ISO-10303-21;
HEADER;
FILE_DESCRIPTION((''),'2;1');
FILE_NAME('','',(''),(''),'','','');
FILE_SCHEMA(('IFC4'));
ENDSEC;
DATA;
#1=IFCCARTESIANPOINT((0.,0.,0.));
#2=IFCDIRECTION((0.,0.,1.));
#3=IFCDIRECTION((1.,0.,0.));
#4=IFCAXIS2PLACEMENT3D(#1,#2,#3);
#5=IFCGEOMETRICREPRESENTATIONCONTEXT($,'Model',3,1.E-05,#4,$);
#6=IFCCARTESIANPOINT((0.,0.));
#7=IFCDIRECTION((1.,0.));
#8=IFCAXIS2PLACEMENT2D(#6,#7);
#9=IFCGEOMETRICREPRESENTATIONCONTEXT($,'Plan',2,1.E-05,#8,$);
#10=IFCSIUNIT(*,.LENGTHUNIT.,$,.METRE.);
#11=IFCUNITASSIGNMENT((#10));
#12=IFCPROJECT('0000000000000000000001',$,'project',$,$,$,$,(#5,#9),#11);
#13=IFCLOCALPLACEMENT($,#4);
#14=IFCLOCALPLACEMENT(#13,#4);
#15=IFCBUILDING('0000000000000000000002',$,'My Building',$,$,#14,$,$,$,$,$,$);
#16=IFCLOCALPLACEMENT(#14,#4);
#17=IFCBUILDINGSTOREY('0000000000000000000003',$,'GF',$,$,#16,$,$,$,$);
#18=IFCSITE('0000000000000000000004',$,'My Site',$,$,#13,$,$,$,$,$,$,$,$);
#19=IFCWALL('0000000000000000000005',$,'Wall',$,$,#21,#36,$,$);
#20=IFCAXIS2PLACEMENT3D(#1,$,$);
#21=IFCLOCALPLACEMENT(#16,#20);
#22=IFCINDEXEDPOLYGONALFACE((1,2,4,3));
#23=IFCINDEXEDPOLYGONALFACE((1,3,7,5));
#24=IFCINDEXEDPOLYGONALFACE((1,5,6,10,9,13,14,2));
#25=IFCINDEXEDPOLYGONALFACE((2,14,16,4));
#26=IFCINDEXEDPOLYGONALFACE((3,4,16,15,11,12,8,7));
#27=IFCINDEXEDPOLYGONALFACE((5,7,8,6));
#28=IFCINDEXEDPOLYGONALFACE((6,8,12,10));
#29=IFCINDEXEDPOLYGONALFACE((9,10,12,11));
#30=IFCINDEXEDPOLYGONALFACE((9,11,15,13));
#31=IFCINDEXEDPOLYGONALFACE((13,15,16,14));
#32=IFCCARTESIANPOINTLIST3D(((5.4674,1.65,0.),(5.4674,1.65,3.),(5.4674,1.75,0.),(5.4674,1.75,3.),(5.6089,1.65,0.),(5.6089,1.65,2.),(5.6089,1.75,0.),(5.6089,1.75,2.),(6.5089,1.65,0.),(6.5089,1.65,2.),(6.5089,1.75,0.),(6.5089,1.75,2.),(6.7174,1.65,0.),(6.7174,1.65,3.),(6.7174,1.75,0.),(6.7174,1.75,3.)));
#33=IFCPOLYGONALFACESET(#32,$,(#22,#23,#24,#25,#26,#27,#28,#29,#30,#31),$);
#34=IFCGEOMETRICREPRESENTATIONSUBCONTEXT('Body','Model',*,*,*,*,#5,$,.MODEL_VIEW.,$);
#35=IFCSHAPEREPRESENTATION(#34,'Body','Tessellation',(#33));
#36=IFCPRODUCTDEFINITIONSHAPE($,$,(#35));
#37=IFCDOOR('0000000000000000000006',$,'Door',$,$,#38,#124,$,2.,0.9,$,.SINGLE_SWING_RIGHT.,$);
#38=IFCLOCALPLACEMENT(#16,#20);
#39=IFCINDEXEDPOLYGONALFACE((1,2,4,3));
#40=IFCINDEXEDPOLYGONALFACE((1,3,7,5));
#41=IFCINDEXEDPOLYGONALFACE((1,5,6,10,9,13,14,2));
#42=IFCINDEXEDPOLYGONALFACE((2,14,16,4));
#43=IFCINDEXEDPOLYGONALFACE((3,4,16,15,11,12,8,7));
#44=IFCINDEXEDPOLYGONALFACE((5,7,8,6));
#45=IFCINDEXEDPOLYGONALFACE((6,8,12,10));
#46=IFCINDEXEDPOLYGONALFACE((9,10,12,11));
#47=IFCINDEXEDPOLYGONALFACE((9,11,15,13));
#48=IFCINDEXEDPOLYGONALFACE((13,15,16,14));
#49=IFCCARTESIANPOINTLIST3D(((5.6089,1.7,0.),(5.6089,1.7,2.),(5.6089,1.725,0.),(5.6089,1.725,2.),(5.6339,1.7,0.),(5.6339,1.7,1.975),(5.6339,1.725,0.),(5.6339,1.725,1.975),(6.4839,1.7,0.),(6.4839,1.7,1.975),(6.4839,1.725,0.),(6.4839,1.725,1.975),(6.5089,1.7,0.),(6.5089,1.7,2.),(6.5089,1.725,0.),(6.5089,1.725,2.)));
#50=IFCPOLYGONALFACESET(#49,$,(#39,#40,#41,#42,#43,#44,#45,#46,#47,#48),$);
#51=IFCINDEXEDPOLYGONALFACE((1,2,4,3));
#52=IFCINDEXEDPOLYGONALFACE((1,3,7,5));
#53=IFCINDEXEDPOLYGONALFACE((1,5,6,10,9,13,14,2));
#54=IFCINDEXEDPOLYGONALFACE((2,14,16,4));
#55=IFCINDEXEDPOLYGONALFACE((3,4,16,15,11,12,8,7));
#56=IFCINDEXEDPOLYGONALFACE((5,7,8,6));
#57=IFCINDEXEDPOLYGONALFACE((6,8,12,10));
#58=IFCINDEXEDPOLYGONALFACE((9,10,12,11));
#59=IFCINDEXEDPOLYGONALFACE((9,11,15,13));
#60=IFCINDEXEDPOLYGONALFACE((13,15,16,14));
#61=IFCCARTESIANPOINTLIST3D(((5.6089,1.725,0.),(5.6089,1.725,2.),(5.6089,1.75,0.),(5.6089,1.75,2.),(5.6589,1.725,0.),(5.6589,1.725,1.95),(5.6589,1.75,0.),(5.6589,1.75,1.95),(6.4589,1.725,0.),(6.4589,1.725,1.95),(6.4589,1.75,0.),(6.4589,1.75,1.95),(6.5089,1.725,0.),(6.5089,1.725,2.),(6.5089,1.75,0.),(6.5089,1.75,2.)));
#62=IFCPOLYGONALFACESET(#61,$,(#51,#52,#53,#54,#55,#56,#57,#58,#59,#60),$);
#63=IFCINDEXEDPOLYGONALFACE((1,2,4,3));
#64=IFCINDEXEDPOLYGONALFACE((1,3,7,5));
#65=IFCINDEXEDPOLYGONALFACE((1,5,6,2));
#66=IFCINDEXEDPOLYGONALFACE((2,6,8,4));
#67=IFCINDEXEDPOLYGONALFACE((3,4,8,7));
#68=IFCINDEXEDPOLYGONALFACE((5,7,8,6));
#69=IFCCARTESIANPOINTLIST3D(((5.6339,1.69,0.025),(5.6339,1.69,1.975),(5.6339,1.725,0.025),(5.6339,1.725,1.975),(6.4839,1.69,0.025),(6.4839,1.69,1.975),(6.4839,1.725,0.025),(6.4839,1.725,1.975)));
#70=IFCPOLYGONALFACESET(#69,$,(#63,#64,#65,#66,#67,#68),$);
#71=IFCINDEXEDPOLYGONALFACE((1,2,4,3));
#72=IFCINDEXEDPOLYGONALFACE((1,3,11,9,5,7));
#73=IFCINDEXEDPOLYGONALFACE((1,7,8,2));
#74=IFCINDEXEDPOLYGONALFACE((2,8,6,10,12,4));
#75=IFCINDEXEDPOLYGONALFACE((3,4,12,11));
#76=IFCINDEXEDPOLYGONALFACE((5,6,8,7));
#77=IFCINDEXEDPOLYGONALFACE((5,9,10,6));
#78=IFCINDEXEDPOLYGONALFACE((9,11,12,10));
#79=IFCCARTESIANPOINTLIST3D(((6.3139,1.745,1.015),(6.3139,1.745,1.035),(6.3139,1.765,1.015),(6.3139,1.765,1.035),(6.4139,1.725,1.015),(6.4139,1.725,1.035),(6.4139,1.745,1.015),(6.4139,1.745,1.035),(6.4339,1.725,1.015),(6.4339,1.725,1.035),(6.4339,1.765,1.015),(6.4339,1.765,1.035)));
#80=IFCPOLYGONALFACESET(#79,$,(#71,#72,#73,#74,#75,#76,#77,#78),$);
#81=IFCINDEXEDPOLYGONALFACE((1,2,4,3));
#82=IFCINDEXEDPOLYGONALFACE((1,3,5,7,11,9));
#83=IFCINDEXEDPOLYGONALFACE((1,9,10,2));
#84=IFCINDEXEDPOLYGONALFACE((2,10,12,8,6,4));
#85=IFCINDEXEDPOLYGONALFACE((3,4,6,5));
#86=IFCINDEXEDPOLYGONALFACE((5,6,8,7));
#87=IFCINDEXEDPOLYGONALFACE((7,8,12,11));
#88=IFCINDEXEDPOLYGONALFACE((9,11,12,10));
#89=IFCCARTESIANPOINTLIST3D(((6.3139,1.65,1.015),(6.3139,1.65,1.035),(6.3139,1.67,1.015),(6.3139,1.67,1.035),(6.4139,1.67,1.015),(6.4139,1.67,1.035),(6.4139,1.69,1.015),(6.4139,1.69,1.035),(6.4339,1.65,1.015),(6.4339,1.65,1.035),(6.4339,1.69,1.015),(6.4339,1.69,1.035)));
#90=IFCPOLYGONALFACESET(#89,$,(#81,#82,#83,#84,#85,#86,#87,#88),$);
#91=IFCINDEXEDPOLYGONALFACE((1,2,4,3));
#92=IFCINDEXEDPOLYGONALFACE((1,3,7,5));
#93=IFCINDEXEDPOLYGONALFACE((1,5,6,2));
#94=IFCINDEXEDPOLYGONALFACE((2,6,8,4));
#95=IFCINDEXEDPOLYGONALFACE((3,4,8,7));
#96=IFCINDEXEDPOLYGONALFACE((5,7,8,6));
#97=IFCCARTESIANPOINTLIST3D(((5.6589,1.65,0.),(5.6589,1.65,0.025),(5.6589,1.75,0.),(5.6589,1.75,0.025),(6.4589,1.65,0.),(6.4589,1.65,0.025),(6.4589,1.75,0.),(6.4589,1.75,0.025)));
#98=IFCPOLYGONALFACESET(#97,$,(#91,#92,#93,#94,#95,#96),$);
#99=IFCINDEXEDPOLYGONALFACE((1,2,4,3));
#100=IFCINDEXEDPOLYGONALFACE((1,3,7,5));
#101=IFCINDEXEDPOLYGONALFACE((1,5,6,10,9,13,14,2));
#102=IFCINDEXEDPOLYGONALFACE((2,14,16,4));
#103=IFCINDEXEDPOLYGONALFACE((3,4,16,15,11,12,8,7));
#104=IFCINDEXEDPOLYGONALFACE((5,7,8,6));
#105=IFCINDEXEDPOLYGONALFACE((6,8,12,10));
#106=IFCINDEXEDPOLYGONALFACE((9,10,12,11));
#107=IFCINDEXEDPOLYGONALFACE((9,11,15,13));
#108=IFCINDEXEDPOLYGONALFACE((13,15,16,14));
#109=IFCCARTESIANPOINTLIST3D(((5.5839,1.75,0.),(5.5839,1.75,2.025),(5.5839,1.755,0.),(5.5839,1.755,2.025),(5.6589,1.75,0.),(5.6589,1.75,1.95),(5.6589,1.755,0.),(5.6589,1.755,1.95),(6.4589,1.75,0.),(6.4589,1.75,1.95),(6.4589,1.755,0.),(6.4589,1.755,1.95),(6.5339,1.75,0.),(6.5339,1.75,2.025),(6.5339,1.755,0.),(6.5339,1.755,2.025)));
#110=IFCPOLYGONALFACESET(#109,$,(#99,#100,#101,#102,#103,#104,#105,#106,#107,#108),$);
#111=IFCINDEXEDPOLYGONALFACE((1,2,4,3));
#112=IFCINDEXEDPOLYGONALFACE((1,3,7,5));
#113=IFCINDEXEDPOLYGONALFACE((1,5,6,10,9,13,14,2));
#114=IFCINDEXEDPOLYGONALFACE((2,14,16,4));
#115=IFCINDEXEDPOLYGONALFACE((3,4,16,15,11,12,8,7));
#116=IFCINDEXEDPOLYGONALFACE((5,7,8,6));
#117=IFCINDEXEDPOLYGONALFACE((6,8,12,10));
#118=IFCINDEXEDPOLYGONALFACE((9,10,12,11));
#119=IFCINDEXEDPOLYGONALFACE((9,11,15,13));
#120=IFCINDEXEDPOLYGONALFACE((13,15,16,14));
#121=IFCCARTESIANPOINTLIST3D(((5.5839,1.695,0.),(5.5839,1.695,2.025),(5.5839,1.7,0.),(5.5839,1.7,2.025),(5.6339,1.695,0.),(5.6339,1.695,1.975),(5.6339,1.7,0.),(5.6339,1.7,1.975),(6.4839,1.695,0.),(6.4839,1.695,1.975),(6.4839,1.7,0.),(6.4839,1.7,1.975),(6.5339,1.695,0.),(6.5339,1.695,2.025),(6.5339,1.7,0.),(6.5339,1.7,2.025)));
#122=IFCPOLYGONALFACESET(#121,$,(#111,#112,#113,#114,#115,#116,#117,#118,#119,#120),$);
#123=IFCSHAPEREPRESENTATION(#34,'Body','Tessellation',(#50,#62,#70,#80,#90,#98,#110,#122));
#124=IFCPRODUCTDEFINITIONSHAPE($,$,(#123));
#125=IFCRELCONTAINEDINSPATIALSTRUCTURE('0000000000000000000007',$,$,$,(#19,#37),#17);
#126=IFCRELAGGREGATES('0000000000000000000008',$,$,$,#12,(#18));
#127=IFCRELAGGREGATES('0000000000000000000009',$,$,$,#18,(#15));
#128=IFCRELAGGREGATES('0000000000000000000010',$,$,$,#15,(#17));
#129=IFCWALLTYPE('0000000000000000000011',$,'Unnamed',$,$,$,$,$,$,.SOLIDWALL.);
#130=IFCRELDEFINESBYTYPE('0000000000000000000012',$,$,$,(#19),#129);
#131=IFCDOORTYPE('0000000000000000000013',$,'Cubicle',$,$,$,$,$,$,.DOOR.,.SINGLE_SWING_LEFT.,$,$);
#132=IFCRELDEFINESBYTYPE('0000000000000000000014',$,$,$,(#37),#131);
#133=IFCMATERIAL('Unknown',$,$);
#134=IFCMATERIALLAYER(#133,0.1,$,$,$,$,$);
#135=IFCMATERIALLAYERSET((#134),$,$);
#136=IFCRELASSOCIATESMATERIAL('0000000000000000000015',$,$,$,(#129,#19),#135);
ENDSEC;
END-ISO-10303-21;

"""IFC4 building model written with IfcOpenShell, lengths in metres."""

from ifc_helpers import new_model, entity, si_unit, frame, origin_with_axes, origin_2d_with_axis, place, context, subcontext, project, spatial, line, indexed_curve, outline, extrude, shape, source, transform, mapped, material, layer, layer_set, layer_usage, type_object, type_shapes, element, fill, save


model = new_model("IFC4")

# Units and contexts
model_context = context("Model", 3, precision=1e-05, world=origin_with_axes())
plan_context = context("Plan", 2, precision=1e-05, world=origin_2d_with_axis())
body_context_1 = subcontext(model_context, "Body", "Model", "MODEL_VIEW")
body_context_2 = subcontext(plan_context, "Body", "Plan", "PLAN_VIEW")
ifc_project = project(units=[si_unit("LENGTHUNIT", "METRE")], contexts=[model_context, plan_context])

# Site, building, storey
site_placement = place(None, origin_with_axes())
site = spatial("IfcSite", under=ifc_project, at=site_placement, Name="My Site")
building_placement = place(site_placement, origin_with_axes())
building = spatial("IfcBuilding", under=site, at=building_placement, Name="My Building")
storey_placement = place(building_placement, origin_with_axes())
storey = spatial("IfcBuildingStorey", under=building, at=storey_placement, Name="GF")

# Shared definitions
ifc_material = material(Name="Unknown")

# Shared definitions
ifc_layer_1 = layer(ifc_material, 0.1)
ifc_layer_set_1 = layer_set([ifc_layer_1])
wall_type = type_object("IfcWallType", Name="Unnamed", PredefinedType="SOLIDWALL", material=ifc_layer_set_1)

# Wall, opening, door
shared_shape_1 = source(origin_with_axes(), body_context_1, "Body", "SweptSolid", [
    extrude(outline(indexed_curve([(0.0, 0.0), (0.9, 0.0), (0.9, 2.0), (0.0, 2.0)], segments=[line(1, 2, 3, 4, 1)])), frame((0.0, -0.6, 0.0), z_axis=(0.0, -1.0, 0.0), x_axis=(1.0, 0.0, 0.0)), (0.0, 0.0, -1.0), 1.2),
])
door_type = type_object("IfcDoorType", Name="Cubicle", OperationType="SINGLE_SWING_LEFT", PredefinedType="DOOR")
shared_shape_2 = source(origin_with_axes(), body_context_1, "Body", "SweptSolid", [
    extrude(outline(indexed_curve([(0.0, 0.0), (0.0, 2.0), (0.9, 2.0), (0.9, 0.0), (0.875, 0.0), (0.875, 1.975), (0.025, 1.975), (0.025, 0.0)], segments=[line(1, 2, 3, 4, 5, 6, 7, 8, 1)])), frame((0.0, 0.025, 0.0), z_axis=(0.0, -1.0, 0.0), x_axis=(1.0, 0.0, 0.0)), (0.0, 0.0, -1.0), 0.025),
    extrude(outline(indexed_curve([(0.0, 0.0), (0.0, 2.0), (0.9, 2.0), (0.9, 0.0), (0.85, 0.0), (0.85, 1.95), (0.05, 1.95), (0.05, 0.0)], segments=[line(1, 2, 3, 4, 5, 6, 7, 8, 1)])), frame((0.0, 0.0, 0.0), z_axis=(0.0, -1.0, 0.0), x_axis=(1.0, 0.0, 0.0)), (0.0, 0.0, -1.0), 0.025),
    extrude(outline(indexed_curve([(0.0, 0.0), (0.85, 0.0), (0.85, 0.035), (0.0, 0.035)], segments=[line(1, 2, 3, 4, 1)])), frame((0.025, 0.025, 0.025), z_axis=(0.0, 0.0, 1.0), x_axis=(1.0, 0.0, 0.0)), (0.0, 0.0, 1.0), 1.95),
    extrude(outline(indexed_curve([(0.0, 0.0), (0.0, -0.04), (0.12, -0.04), (0.12, -0.02), (0.02, -0.02), (0.02, 0.0)], segments=[line(1, 2, 3, 4, 5, 6, 1)])), frame((0.075, 0.025, 1.015), z_axis=(0.0, 0.0, 1.0), x_axis=(1.0, 0.0, 0.0)), (0.0, 0.0, 1.0), 0.02),
    extrude(outline(indexed_curve([(0.0, 0.0), (0.0, 0.04), (0.12, 0.04), (0.12, 0.02), (0.02, 0.02), (0.02, 0.0)], segments=[line(1, 2, 3, 4, 5, 6, 1)])), frame((0.075, 0.06, 1.015), z_axis=(0.0, 0.0, 1.0), x_axis=(1.0, 0.0, 0.0)), (0.0, 0.0, 1.0), 0.02),
    extrude(outline(indexed_curve([(0.0, 0.0), (0.8, 0.0), (0.8, 0.1), (0.0, 0.1)], segments=[line(1, 2, 3, 4, 1)])), frame((0.05, 0.0, 0.0), z_axis=(0.0, 0.0, 1.0), x_axis=(1.0, 0.0, 0.0)), (0.0, 0.0, 1.0), 0.025),
    extrude(outline(indexed_curve([(0.0, 0.0), (0.0, 2.025), (0.95, 2.025), (0.95, 0.0), (0.875, 0.0), (0.875, 1.95), (0.075, 1.95), (0.075, 0.0)], segments=[line(1, 2, 3, 4, 5, 6, 7, 8, 1)])), frame((-0.025, -0.005, 0.0), z_axis=(0.0, -1.0, 0.0), x_axis=(1.0, 0.0, 0.0)), (0.0, 0.0, -1.0), 0.005),
    extrude(outline(indexed_curve([(0.0, 0.0), (0.0, 2.025), (0.95, 2.025), (0.95, 0.0), (0.9, 0.0), (0.9, 1.975), (0.05, 1.975), (0.05, 0.0)], segments=[line(1, 2, 3, 4, 5, 6, 7, 8, 1)])), frame((-0.025, 0.05, 0.0), z_axis=(0.0, -1.0, 0.0), x_axis=(1.0, 0.0, 0.0)), (0.0, 0.0, -1.0), 0.005),
])
shared_shape_3 = source(origin_with_axes(), body_context_2, "Body", "Curve2D", [
    entity("IfcIndexedPolyCurve", entity("IfcCartesianPointList2D", [[0.0, 0.0], [0.0, 0.05], [0.025, 0.05], [0.025, 0.025], [0.05, 0.025], [0.05, 0.0]]), [entity("IfcLineIndex", [1, 2, 3, 4, 5, 6, 1])]),
    entity("IfcIndexedPolyCurve", entity("IfcCartesianPointList2D", [[0.9, 0.0], [0.9, 0.05], [0.875, 0.05], [0.875, 0.025], [0.85, 0.025], [0.85, 0.0]]), [entity("IfcLineIndex", [1, 2, 3, 4, 5, 6, 1])]),
    entity("IfcTrimmedCurve", entity("IfcEllipse", entity("IfcAxis2Placement2D", entity("IfcCartesianPoint", [0.84, 0.05]), entity("IfcDirection", [1.0, 0.0])), 0.815, 0.85), [entity("IfcCartesianPoint", [0.84, 0.9])], [entity("IfcCartesianPoint", [0.025, 0.05])], True, "CARTESIAN"),
    entity("IfcIndexedPolyCurve", entity("IfcCartesianPointList2D", [[0.875, 0.05], [0.84, 0.05], [0.84, 0.9], [0.875, 0.9]]), [entity("IfcLineIndex", [1, 2, 3, 4, 1])]),
])
type_shapes(door_type, [shared_shape_2, shared_shape_3])
ifc_layer_usage_1 = layer_usage(ifc_layer_set_1, "AXIS2", "POSITIVE", 0.0)
wall_1_placement = place(storey_placement, frame((6.7174, 1.75, 0.0), z_axis=(0.0, 0.0, 1.0), x_axis=(-1.0, 0.0, 0.0)))
wall_1 = element("IfcWall", 1, at=wall_1_placement, inside=storey, type_object=wall_type, material=ifc_layer_usage_1, Name="Wall", context=body_context_1, shape_type="SweptSolid", body=[
    extrude(outline(indexed_curve([(0.0, 0.0), (0.0, 0.1), (1.25, 0.1), (1.25, 0.0)], segments=[line(1, 2, 3, 4, 1)])), origin_with_axes(), (0.0, 0.0, 1.0), 3.0),
])
opening_1_placement = place(wall_1_placement, frame((0.2085, 0.0, 0.0), z_axis=(0.0, 0.0, 1.0), x_axis=(1.0, 0.0, 0.0)))
opening_1 = element("IfcOpeningElement", 2, at=opening_1_placement, cuts=wall_1, PredefinedType="OPENING", context=body_context_1, shape_type="MappedRepresentation", body=[
    mapped(shared_shape_1, transform((0.0, 0.0, 0.0), x_axis=(1.0, 0.0, 0.0), y_axis=(0.0, 1.0, 0.0), z_axis=(0.0, 0.0, 1.0), scale=1.0)),
])
door_1_placement = place(opening_1_placement, frame((0.0, 0.0, 0.0), z_axis=(0.0, 0.0, 1.0), x_axis=(1.0, 0.0, 0.0)))
door_1 = element("IfcDoor", 3, at=door_1_placement, inside=storey, type_object=door_type, Name="Door", OperationType="SINGLE_SWING_RIGHT", OverallHeight=2.0, OverallWidth=0.9, shapes=[
    shape(body_context_1, "Body", "MappedRepresentation", [mapped(shared_shape_2, transform((0.0, 0.0, 0.0), x_axis=(1.0, 0.0, 0.0), y_axis=(0.0, 1.0, 0.0), z_axis=(0.0, 0.0, 1.0), scale=1.0))]),
    shape(body_context_2, "Body", "MappedRepresentation", [mapped(shared_shape_3, transform((0.0, 0.0, 0.0), x_axis=(1.0, 0.0, 0.0), y_axis=(0.0, 1.0, 0.0), z_axis=(0.0, 0.0, 1.0), scale=1.0))]),
])
fill(opening_1, door_1)

save(model, "model.ifc")
